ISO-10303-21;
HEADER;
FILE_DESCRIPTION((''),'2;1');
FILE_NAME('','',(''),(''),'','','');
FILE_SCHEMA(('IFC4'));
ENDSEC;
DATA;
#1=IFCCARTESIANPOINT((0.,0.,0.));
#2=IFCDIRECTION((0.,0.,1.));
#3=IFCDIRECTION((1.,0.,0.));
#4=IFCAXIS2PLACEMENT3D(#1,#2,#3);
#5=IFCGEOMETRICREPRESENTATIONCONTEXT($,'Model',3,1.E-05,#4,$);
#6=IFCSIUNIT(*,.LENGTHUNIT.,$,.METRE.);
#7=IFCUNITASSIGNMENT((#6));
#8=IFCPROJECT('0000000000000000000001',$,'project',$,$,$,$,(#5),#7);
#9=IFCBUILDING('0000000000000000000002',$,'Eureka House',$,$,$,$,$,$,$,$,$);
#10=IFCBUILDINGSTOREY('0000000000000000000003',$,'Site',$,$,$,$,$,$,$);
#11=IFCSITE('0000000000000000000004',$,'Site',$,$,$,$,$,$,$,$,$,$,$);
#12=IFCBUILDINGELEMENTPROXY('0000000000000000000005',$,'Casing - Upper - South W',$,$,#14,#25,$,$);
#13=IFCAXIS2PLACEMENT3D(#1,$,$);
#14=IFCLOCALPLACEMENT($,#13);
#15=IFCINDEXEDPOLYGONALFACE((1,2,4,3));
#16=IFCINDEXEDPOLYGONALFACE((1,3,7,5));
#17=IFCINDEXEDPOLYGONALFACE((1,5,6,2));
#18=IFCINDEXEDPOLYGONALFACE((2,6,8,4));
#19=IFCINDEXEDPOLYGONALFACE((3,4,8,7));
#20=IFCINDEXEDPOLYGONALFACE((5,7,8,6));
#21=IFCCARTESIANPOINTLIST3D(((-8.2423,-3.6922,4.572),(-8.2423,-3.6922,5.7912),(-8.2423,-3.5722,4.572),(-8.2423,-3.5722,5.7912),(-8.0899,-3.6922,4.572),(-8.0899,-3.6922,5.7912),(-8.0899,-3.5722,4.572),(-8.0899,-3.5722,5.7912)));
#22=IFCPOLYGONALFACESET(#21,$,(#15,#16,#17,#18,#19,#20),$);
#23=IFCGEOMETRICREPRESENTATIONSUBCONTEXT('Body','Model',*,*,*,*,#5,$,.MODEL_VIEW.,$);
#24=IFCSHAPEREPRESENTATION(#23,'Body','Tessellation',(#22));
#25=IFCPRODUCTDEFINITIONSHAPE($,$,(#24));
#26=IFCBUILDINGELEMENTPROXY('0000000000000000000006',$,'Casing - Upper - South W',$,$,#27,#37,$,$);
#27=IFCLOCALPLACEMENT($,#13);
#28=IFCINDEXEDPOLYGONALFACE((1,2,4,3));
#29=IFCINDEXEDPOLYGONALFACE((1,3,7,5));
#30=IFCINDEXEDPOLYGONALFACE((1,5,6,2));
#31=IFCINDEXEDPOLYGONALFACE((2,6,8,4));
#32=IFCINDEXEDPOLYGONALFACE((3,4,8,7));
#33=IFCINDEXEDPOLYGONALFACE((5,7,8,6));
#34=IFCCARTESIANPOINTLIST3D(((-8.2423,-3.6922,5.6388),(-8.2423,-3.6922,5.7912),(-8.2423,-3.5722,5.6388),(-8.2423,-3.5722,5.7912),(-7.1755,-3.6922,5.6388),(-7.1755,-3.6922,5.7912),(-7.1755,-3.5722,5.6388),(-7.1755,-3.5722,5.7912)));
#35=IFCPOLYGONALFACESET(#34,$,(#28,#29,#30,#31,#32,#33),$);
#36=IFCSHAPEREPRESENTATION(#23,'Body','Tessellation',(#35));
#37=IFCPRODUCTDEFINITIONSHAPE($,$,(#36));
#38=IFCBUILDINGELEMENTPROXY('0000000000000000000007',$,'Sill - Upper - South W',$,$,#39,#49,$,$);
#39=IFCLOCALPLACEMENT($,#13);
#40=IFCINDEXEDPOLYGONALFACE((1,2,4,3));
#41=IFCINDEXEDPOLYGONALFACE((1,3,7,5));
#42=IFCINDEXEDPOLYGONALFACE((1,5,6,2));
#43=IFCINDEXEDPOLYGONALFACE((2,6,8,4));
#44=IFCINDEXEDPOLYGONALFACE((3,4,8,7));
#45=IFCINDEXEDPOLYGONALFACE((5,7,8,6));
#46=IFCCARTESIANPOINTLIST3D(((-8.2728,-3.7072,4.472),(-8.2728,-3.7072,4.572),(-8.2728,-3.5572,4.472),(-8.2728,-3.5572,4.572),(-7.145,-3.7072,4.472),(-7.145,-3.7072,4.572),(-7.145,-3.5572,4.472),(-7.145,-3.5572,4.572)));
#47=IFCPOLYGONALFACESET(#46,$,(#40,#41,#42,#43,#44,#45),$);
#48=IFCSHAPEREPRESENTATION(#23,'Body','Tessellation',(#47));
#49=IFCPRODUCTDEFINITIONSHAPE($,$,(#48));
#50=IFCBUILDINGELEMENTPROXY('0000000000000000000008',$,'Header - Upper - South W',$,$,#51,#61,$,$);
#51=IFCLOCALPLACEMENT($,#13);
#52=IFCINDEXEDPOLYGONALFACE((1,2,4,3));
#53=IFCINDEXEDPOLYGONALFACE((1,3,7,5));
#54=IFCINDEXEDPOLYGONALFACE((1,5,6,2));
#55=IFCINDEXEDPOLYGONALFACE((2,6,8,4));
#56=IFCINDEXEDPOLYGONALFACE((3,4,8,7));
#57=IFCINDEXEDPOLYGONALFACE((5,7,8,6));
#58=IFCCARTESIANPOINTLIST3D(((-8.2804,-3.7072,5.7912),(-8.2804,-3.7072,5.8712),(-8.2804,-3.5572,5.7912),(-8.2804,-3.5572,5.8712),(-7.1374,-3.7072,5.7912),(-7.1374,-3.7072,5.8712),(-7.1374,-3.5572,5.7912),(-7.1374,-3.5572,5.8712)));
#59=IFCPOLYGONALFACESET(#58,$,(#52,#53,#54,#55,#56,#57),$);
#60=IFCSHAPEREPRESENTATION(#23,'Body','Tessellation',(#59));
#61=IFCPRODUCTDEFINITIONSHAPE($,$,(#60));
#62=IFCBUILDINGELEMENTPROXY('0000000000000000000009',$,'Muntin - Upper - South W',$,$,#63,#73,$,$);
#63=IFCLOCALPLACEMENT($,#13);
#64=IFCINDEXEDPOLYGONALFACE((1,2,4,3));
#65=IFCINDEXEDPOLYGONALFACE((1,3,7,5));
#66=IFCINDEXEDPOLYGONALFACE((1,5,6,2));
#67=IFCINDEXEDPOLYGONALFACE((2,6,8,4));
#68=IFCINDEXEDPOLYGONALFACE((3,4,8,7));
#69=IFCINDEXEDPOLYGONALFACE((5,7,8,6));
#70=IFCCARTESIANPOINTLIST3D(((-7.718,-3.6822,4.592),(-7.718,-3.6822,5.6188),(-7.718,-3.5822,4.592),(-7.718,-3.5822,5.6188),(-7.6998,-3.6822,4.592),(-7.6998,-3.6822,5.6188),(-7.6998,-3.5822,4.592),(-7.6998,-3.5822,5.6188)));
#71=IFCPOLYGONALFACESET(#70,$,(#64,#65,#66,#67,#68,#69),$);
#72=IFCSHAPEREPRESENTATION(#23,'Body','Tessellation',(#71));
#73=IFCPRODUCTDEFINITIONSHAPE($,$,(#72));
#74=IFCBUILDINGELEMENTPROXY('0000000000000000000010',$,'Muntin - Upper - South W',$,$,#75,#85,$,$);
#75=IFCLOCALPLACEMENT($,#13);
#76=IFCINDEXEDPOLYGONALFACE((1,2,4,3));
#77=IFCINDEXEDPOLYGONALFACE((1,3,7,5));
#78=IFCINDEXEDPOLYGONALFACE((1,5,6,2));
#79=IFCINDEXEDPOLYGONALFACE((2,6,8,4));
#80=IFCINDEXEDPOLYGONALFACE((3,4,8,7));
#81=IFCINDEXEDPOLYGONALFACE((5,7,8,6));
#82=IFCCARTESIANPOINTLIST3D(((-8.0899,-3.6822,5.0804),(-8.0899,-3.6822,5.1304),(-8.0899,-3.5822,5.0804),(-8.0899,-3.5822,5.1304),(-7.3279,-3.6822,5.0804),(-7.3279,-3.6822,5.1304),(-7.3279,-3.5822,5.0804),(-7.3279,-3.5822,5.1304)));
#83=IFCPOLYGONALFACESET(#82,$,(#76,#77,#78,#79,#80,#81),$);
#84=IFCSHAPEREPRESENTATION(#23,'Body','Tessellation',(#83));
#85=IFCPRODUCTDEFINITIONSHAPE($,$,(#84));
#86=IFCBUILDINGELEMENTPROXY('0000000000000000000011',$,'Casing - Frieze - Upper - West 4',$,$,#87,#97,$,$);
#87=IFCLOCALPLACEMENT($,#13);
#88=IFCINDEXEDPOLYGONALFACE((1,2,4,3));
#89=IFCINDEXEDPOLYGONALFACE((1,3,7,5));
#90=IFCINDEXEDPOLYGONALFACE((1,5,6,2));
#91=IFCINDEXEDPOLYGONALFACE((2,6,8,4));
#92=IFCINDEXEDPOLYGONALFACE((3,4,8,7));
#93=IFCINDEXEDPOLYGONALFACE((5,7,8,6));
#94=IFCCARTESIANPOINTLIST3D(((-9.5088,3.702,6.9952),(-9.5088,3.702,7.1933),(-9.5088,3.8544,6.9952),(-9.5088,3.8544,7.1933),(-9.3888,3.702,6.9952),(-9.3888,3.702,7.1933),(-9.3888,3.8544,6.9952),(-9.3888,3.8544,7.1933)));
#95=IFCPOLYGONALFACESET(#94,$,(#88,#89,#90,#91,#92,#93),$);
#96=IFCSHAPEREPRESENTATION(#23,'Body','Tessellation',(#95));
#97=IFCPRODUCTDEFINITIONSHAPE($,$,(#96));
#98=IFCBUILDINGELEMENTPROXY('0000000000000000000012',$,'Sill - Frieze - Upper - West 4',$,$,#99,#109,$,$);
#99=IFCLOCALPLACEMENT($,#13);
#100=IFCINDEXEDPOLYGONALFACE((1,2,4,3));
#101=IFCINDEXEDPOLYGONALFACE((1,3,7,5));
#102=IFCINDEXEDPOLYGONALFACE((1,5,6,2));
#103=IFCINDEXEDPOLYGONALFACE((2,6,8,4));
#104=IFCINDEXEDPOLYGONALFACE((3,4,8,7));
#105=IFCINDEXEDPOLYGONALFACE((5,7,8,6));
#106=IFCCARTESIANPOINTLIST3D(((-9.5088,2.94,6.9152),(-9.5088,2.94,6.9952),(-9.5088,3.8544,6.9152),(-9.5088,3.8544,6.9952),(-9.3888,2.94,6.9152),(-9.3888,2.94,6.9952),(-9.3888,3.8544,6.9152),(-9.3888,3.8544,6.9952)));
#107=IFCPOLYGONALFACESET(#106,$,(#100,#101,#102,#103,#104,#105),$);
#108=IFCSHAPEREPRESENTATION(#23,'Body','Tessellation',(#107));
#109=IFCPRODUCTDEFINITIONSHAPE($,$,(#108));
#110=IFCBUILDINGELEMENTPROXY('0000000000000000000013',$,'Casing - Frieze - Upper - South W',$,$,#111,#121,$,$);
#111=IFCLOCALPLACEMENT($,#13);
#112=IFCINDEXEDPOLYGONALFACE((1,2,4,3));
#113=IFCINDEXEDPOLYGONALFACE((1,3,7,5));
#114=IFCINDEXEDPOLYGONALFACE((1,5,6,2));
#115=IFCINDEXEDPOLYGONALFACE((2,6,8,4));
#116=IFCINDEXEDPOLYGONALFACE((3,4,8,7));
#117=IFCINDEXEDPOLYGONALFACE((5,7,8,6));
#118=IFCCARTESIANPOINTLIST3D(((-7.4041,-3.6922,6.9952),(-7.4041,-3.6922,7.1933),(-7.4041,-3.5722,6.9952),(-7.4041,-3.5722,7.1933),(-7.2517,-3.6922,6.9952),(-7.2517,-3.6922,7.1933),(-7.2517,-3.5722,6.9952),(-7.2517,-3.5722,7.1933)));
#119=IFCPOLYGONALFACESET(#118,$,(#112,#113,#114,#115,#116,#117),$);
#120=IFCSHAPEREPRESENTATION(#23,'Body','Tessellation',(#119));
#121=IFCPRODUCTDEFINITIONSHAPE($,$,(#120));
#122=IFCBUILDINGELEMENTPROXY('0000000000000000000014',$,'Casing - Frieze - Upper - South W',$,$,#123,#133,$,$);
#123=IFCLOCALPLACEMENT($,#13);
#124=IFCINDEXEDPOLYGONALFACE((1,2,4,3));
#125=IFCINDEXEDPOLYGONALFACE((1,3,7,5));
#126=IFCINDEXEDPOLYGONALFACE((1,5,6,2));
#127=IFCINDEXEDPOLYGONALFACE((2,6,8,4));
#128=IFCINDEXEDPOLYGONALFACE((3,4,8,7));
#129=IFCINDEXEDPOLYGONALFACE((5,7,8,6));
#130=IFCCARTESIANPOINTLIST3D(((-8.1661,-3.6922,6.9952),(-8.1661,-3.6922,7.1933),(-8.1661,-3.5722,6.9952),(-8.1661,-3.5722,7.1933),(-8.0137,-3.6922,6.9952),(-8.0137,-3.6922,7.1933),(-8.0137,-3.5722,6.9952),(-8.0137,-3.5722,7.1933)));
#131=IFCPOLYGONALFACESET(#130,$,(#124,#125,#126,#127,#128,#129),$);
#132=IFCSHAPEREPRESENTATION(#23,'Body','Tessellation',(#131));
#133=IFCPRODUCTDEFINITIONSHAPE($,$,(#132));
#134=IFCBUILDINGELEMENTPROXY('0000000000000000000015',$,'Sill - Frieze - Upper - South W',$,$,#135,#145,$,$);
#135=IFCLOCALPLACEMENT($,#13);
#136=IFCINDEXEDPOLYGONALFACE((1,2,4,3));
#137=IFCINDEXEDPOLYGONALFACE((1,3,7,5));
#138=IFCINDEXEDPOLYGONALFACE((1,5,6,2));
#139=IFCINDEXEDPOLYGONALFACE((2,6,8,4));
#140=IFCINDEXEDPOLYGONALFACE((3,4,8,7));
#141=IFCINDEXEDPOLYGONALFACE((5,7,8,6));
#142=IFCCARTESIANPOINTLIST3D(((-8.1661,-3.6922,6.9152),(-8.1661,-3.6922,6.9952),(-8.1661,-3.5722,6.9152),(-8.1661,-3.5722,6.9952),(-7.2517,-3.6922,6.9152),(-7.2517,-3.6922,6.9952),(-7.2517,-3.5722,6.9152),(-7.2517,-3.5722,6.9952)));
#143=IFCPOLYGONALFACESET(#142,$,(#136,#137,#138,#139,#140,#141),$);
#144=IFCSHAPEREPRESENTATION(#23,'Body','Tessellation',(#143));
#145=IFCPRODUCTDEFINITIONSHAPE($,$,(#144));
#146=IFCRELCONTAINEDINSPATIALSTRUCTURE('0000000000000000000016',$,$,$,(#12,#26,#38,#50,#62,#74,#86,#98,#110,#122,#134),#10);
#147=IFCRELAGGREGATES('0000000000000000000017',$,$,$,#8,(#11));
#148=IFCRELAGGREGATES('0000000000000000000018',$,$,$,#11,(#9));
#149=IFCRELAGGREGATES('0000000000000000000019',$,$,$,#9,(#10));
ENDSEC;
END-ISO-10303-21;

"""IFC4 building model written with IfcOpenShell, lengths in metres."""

from ifc_helpers import new_model, si_unit, frame, origin, origin_with_axes, origin_2d, place, context, subcontext, project, spatial, rectangle, extrude, element, save


model = new_model("IFC4")

# Units and contexts
model_context = context("Model", 3, precision=1e-05, world=origin_with_axes())
body_context = subcontext(model_context, "Body", "Model", "MODEL_VIEW")
ifc_project = project(units=[si_unit("LENGTHUNIT", "METRE")], contexts=[model_context])

# Site, building, storey
site = spatial("IfcSite", under=ifc_project, Name="Site")
building = spatial("IfcBuilding", under=site, Name="Eureka House")
storey = spatial("IfcBuildingStorey", under=building, Name="Site")

# Building element proxies
for number, where, z_axis, x_axis, name in (
    (1, (-8.1661, -3.6322, 4.572), (0.0, 0.0, 1.0), (1.0, 0.0, 0.0), "Casing - Upper - South W"),
):
    element("IfcBuildingElementProxy", number, at=place(None, frame(where, z_axis=z_axis, x_axis=x_axis)), inside=storey, Name=name, context=body_context, shape_type="SweptSolid", body=[
        extrude(rectangle(XDim=0.1524, YDim=0.12, at=origin_2d()), origin(), (0.0, 0.0, 1.0), 1.2192),
    ])
proxy_1_placement = place(None, frame((-7.7089, -3.6322, 5.6388), z_axis=(0.0, 0.0, 1.0), x_axis=(1.0, 0.0, 0.0)))
element("IfcBuildingElementProxy", 2, at=proxy_1_placement, inside=storey, Name="Casing - Upper - South W", context=body_context, shape_type="SweptSolid", body=[
    extrude(rectangle(XDim=1.0668, YDim=0.12, at=origin_2d()), origin(), (0.0, 0.0, 1.0), 0.1524),
])
proxy_2_placement = place(None, frame((-7.7089, -3.6322, 4.472), z_axis=(0.0, 0.0, 1.0), x_axis=(1.0, 0.0, 0.0)))
element("IfcBuildingElementProxy", 3, at=proxy_2_placement, inside=storey, Name="Sill - Upper - South W", context=body_context, shape_type="SweptSolid", body=[
    extrude(rectangle(XDim=1.1278, YDim=0.15, at=origin_2d()), origin(), (0.0, 0.0, 1.0), 0.1),
])
proxy_3_placement = place(None, frame((-7.7089, -3.6322, 5.7912), z_axis=(0.0, 0.0, 1.0), x_axis=(1.0, 0.0, 0.0)))
element("IfcBuildingElementProxy", 4, at=proxy_3_placement, inside=storey, Name="Header - Upper - South W", context=body_context, shape_type="SweptSolid", body=[
    extrude(rectangle(XDim=1.143, YDim=0.15, at=origin_2d()), origin(), (0.0, 0.0, 1.0), 0.08),
])
proxy_4_placement = place(None, frame((-7.7089, -3.6322, 4.592), z_axis=(0.0, 0.0, 1.0), x_axis=(1.0, 0.0, 0.0)))
element("IfcBuildingElementProxy", 5, at=proxy_4_placement, inside=storey, Name="Muntin - Upper - South W", context=body_context, shape_type="SweptSolid", body=[
    extrude(rectangle(XDim=0.0183, YDim=0.1, at=origin_2d()), origin(), (0.0, 0.0, 1.0), 1.0268),
])
proxy_5_placement = place(None, frame((-7.7089, -3.6322, 5.0804), z_axis=(0.0, 0.0, 1.0), x_axis=(1.0, 0.0, 0.0)))
element("IfcBuildingElementProxy", 6, at=proxy_5_placement, inside=storey, Name="Muntin - Upper - South W", context=body_context, shape_type="SweptSolid", body=[
    extrude(rectangle(XDim=0.762, YDim=0.1, at=origin_2d()), origin(), (0.0, 0.0, 1.0), 0.05),
])
proxy_6_placement = place(None, frame((-9.4488, 3.7782, 6.9952), z_axis=(0.0, 0.0, 1.0), x_axis=(1.0, 0.0, 0.0)))
element("IfcBuildingElementProxy", 7, at=proxy_6_placement, inside=storey, Name="Casing - Frieze - Upper - West 4", context=body_context, shape_type="SweptSolid", body=[
    extrude(rectangle(XDim=0.12, YDim=0.1524, at=origin_2d()), origin(), (0.0, 0.0, 1.0), 0.1981),
])
proxy_7_placement = place(None, frame((-9.4488, 3.3972, 6.9152), z_axis=(0.0, 0.0, 1.0), x_axis=(1.0, 0.0, 0.0)))
element("IfcBuildingElementProxy", 8, at=proxy_7_placement, inside=storey, Name="Sill - Frieze - Upper - West 4", context=body_context, shape_type="SweptSolid", body=[
    extrude(rectangle(XDim=0.12, YDim=0.9144, at=origin_2d()), origin(), (0.0, 0.0, 1.0), 0.08),
])
for number, where, z_axis, x_axis, name in (
    (9, (-7.3279, -3.6322, 6.9952), (0.0, 0.0, 1.0), (1.0, 0.0, 0.0), "Casing - Frieze - Upper - South W"),
    (10, (-8.0899, -3.6322, 6.9952), (0.0, 0.0, 1.0), (1.0, 0.0, 0.0), "Casing - Frieze - Upper - South W"),
):
    element("IfcBuildingElementProxy", number, at=place(None, frame(where, z_axis=z_axis, x_axis=x_axis)), inside=storey, Name=name, context=body_context, shape_type="SweptSolid", body=[
        extrude(rectangle(XDim=0.1524, YDim=0.12, at=origin_2d()), origin(), (0.0, 0.0, 1.0), 0.1981),
    ])
proxy_8_placement = place(None, frame((-7.7089, -3.6322, 6.9152), z_axis=(0.0, 0.0, 1.0), x_axis=(1.0, 0.0, 0.0)))
element("IfcBuildingElementProxy", 11, at=proxy_8_placement, inside=storey, Name="Sill - Frieze - Upper - South W", context=body_context, shape_type="SweptSolid", body=[
    extrude(rectangle(XDim=0.9144, YDim=0.12, at=origin_2d()), origin(), (0.0, 0.0, 1.0), 0.08),
])

save(model, "model.ifc")
